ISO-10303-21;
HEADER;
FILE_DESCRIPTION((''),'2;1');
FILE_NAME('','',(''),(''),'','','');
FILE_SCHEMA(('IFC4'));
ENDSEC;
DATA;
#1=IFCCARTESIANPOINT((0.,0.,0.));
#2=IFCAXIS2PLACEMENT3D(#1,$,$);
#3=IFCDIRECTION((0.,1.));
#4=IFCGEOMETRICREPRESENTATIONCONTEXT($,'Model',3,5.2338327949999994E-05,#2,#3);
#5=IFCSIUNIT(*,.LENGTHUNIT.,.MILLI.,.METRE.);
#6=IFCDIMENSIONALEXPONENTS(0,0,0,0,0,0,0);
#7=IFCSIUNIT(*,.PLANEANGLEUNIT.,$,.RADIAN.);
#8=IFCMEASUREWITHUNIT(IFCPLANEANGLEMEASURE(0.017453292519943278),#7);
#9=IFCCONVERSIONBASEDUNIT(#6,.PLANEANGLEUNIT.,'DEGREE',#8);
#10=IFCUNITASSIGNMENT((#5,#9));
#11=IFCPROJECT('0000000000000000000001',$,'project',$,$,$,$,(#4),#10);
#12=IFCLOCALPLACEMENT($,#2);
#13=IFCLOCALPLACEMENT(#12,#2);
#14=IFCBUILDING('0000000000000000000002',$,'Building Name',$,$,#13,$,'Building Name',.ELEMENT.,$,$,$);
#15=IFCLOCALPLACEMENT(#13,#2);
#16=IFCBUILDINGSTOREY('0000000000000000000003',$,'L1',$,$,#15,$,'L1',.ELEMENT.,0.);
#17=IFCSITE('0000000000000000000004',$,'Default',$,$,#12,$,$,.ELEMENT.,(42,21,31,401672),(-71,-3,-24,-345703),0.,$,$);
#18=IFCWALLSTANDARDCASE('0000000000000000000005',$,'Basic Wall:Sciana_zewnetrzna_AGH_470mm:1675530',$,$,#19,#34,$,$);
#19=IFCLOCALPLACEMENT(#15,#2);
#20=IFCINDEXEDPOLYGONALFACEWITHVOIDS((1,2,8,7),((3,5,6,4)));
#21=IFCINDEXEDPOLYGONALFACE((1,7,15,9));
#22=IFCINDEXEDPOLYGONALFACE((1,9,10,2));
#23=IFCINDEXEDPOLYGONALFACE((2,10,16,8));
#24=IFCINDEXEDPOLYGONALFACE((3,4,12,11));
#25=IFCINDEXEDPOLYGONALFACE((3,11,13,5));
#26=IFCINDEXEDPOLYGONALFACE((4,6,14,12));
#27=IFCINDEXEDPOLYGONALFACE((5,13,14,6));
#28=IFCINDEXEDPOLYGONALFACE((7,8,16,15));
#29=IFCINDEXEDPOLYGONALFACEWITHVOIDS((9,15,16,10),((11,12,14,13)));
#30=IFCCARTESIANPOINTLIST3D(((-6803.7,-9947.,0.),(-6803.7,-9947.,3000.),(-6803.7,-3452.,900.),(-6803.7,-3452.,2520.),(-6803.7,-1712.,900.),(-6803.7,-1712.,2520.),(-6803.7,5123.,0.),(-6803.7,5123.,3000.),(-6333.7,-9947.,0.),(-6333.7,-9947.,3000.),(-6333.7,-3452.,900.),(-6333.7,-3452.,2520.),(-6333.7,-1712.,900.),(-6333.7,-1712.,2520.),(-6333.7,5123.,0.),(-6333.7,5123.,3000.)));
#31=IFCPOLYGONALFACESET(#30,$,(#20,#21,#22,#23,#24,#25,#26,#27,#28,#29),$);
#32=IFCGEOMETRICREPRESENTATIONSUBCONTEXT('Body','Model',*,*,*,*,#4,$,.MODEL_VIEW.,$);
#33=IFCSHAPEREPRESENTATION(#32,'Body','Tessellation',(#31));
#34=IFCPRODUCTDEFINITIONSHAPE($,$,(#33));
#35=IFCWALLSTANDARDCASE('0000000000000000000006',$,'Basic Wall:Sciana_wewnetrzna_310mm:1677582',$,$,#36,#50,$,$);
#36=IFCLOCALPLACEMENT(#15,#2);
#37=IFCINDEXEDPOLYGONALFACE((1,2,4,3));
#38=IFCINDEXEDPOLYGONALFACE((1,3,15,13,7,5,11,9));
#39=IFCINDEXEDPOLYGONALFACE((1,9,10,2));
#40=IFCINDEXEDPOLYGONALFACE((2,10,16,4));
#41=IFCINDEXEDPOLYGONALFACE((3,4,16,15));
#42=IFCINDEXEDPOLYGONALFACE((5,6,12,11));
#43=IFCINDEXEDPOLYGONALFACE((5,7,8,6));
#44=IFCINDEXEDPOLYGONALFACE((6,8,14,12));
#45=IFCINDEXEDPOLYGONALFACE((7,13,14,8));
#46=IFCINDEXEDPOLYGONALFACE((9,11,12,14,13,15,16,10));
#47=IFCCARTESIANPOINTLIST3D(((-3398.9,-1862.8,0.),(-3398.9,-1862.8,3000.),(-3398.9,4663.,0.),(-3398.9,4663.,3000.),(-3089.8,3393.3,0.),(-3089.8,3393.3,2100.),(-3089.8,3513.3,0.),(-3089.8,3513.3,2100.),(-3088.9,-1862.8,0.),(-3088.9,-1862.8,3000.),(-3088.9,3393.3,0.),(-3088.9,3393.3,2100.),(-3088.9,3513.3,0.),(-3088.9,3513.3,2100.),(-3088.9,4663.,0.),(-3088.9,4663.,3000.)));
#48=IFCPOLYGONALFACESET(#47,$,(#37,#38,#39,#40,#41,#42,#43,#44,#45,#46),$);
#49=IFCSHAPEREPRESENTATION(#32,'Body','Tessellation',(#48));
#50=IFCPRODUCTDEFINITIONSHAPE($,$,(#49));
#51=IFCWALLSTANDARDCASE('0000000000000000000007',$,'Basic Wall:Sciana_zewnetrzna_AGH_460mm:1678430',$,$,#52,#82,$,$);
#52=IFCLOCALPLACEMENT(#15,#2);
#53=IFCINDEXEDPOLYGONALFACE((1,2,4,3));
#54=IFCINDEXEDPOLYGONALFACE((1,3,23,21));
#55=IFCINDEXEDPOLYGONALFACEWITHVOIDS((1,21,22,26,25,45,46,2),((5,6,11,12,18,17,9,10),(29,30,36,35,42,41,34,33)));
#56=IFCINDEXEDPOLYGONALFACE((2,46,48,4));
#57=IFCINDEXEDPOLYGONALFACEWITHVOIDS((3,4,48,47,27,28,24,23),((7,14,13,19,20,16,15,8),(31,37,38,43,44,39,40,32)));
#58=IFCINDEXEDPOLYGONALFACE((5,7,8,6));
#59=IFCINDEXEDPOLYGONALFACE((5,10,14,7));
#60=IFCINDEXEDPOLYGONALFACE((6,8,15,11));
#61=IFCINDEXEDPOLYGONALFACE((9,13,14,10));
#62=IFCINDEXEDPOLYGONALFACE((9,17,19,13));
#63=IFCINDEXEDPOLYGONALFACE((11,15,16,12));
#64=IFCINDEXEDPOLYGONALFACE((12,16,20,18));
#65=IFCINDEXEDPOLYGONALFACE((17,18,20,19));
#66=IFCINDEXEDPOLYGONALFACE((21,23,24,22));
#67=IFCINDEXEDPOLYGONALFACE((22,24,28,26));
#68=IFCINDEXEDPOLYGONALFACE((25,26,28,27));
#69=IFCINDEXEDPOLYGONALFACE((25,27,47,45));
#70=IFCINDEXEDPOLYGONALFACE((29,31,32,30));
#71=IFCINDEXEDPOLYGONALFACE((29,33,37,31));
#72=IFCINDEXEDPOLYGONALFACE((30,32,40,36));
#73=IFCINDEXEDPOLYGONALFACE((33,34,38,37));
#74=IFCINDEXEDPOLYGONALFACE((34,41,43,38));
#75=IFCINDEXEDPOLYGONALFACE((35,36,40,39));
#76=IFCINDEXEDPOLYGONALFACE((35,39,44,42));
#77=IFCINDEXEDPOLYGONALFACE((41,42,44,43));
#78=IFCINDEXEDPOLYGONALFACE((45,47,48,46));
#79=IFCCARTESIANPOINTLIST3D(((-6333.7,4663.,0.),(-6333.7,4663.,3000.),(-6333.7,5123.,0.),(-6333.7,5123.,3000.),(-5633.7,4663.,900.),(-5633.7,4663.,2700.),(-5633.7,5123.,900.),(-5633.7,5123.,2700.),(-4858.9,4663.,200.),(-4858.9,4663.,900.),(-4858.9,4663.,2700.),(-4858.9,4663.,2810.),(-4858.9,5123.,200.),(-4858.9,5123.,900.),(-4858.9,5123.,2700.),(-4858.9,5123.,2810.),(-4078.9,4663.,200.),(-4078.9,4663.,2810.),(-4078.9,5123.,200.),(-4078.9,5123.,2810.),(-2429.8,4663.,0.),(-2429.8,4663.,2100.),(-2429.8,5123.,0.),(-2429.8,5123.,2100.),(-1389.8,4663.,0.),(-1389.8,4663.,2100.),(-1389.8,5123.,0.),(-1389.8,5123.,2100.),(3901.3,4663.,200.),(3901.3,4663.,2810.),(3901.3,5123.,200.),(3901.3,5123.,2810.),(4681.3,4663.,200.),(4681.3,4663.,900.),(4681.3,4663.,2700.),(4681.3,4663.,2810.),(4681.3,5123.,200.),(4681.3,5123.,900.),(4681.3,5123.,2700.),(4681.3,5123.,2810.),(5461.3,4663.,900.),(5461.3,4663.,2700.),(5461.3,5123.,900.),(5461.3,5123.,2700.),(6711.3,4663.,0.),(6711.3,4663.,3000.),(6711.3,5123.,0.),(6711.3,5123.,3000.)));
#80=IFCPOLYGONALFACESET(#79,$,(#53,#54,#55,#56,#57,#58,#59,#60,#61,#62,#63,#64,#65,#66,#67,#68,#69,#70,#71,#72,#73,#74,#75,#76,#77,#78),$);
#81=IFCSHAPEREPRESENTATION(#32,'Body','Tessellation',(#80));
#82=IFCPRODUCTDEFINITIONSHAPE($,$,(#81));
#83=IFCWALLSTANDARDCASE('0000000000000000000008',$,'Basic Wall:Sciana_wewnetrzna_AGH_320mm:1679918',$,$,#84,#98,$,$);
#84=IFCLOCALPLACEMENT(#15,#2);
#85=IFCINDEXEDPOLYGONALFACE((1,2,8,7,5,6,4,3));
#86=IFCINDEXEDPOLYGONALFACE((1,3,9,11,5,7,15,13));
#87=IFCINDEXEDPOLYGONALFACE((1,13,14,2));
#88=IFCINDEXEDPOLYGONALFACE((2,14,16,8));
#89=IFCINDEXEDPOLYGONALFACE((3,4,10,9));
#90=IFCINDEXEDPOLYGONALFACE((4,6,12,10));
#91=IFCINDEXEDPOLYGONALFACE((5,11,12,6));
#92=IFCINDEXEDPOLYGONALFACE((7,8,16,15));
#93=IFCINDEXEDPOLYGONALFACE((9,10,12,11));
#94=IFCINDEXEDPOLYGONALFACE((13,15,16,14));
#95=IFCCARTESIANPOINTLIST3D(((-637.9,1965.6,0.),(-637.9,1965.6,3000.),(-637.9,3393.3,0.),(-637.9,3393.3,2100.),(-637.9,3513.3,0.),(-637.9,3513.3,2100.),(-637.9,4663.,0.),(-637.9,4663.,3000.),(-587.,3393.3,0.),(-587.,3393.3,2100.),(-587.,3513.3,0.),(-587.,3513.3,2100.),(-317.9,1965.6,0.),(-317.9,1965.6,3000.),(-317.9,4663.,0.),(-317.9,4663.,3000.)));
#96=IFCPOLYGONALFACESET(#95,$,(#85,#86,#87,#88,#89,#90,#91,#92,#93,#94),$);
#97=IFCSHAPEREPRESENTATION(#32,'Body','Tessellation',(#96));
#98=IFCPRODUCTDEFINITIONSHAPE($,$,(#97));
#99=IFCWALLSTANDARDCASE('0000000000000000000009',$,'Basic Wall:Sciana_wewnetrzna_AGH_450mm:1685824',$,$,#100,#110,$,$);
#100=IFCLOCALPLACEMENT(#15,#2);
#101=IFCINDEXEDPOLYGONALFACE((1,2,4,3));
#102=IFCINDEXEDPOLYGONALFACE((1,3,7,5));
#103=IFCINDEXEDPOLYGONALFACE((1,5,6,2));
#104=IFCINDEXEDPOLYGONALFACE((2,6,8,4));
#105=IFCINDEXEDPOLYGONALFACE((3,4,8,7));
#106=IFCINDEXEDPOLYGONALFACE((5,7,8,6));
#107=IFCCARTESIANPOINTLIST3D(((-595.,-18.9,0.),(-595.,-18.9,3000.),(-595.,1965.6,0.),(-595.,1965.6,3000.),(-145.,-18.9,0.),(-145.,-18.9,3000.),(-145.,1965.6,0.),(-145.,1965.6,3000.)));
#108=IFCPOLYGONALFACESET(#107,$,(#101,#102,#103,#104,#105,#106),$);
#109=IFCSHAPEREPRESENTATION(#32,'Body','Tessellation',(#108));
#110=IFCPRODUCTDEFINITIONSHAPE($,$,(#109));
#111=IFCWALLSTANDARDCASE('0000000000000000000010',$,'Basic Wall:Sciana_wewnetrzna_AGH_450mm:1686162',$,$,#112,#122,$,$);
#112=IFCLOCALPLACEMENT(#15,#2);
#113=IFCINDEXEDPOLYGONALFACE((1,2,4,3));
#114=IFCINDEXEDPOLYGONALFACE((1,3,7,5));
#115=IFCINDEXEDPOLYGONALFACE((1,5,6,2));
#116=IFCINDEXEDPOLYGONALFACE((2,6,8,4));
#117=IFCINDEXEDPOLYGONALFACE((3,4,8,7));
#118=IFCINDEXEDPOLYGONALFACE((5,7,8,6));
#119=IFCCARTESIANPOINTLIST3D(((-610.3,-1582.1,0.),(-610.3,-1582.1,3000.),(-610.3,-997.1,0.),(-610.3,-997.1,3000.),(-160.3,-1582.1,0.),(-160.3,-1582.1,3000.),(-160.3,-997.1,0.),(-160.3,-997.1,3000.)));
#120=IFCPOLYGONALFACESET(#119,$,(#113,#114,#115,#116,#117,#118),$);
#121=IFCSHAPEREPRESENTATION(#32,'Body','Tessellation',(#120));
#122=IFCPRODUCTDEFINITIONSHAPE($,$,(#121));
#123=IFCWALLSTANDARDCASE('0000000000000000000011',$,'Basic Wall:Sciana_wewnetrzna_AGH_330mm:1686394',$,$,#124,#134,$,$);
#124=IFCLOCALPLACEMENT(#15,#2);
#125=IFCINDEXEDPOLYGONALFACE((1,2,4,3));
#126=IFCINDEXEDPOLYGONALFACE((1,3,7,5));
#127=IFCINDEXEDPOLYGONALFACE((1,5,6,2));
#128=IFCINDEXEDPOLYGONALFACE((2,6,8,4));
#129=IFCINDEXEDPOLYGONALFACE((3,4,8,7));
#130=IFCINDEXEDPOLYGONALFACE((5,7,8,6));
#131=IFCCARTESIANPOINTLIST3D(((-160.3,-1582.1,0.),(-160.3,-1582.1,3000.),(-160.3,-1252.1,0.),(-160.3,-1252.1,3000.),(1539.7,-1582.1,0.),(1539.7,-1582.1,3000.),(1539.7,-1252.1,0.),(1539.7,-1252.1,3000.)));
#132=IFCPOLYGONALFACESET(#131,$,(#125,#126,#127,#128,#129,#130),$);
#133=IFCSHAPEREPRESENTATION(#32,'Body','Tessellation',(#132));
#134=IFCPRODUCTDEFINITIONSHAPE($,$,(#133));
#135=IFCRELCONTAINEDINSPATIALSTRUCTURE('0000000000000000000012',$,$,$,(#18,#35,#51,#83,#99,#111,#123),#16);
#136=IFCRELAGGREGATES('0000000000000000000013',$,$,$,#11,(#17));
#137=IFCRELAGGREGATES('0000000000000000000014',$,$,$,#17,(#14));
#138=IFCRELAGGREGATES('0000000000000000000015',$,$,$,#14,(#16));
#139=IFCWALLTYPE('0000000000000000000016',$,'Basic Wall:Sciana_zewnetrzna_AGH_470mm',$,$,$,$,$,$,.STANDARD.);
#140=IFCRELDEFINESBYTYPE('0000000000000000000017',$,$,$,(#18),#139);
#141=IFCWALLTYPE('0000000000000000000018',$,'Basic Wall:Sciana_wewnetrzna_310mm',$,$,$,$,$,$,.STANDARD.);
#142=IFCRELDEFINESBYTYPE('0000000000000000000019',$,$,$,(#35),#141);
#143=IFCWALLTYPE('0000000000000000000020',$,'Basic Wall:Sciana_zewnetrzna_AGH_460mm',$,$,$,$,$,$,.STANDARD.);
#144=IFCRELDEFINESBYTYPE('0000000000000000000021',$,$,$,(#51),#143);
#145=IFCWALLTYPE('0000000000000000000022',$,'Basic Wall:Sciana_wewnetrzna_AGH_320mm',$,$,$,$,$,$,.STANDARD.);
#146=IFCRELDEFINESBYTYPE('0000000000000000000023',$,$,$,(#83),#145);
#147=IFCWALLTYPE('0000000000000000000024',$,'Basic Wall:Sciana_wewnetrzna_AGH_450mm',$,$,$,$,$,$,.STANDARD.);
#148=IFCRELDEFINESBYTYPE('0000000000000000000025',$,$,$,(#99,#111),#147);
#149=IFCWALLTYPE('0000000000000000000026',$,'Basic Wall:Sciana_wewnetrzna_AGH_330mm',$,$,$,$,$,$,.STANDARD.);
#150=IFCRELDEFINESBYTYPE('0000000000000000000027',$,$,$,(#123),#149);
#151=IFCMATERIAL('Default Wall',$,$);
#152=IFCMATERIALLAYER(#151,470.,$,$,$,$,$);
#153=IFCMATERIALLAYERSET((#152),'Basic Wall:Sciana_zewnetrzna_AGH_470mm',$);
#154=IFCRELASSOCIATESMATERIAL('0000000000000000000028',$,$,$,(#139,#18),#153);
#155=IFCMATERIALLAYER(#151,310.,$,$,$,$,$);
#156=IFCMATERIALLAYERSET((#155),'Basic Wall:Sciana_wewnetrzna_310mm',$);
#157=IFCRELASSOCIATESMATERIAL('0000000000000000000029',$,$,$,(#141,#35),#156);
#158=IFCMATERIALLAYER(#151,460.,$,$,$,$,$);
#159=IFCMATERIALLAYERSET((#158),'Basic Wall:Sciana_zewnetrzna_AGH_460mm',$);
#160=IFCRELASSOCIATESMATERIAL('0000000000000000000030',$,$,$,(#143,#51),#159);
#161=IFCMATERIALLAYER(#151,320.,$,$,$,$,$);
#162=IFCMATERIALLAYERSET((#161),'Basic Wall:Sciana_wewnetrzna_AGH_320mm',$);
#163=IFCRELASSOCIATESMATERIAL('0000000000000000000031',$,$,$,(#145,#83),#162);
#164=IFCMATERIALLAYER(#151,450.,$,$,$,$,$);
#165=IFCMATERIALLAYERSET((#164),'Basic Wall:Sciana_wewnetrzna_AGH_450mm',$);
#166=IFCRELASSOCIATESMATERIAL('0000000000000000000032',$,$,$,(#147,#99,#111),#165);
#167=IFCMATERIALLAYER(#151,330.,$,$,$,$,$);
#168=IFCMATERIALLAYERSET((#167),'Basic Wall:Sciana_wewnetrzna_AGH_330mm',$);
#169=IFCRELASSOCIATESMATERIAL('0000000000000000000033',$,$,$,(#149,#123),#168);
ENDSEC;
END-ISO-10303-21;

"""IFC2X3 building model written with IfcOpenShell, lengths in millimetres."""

from ifc_helpers import new_model, entity, si_unit, converted_unit, direction, frame, frame_2d, origin, place, context, subcontext, project, spatial, rectangle, extrude, material, layer, layer_set, layer_usage, type_object, element, save


model = new_model("IFC2X3")

# Units and contexts
model_context = context("Model", 3, precision=5.2338327949999994e-05, world=origin(), true_north=direction((0.0, 1.0)))
body_context = subcontext(model_context, "Body", "Model", "MODEL_VIEW")
ifc_project = project(units=[si_unit("LENGTHUNIT", "METRE", prefix="MILLI"), converted_unit("PLANEANGLEUNIT", "DEGREE", entity("IfcPlaneAngleMeasure", 0.017453292519943278), si_unit("PLANEANGLEUNIT", "RADIAN"), dimensions=[0, 0, 0, 0, 0, 0, 0])], contexts=[model_context])

# Site, building, storey
site_placement = place(None, origin())
site = spatial("IfcSite", under=ifc_project, at=site_placement, Name="Default", CompositionType="ELEMENT", RefLatitude=(42, 21, 31, 401672), RefLongitude=(-71, -3, -24, -345703), RefElevation=0.0)
building_placement = place(site_placement, origin())
building = spatial("IfcBuilding", under=site, at=building_placement, Name="Building Name", LongName="Building Name", CompositionType="ELEMENT")
storey_placement = place(building_placement, origin())
storey = spatial("IfcBuildingStorey", under=building, at=storey_placement, Name="L1", LongName="L1", CompositionType="ELEMENT", Elevation=0.0)

# Walls, openings
ifc_material_1 = material(Name="Default Wall")
ifc_layer_1 = layer(ifc_material_1, 470.0)
ifc_layer_set_1 = layer_set([ifc_layer_1], Name="Basic Wall:Sciana_zewnetrzna_AGH_470mm")
ifc_layer_usage_1 = layer_usage(ifc_layer_set_1, "AXIS2", "NEGATIVE", 235.0)
wall_type_1 = type_object("IfcWallType", Name="Basic Wall:Sciana_zewnetrzna_AGH_470mm", PredefinedType="STANDARD", material=ifc_layer_set_1)
wall_1_placement = place(storey_placement, frame((-6568.7, 5123.0, 0.0), z_axis=(0.0, 0.0, 1.0), x_axis=(0.0, -1.0, 0.0)))
wall_1 = element("IfcWallStandardCase", 1, at=wall_1_placement, inside=storey, type_object=wall_type_1, material=ifc_layer_usage_1, Name="Basic Wall:Sciana_zewnetrzna_AGH_470mm:1675530", context=body_context, shape_type="SweptSolid", body=[
    extrude(rectangle(XDim=15070.0, YDim=470.0, at=frame_2d((7535.0, 0.0), x_axis=(-1.0, 0.0))), origin(), (0.0, 0.0, 1.0), 3000.0),
])
opening_1_placement = place(wall_1_placement, frame((8575.0, 235.0, 900.0)))
element("IfcOpeningElement", 2, at=opening_1_placement, cuts=wall_1, ObjectType="Opening", context=body_context, shape_type="SweptSolid", body=[
    extrude(rectangle(XDim=1620.0, YDim=1740.0, at=frame_2d((810.0, 870.0), x_axis=(-1.0, 0.0))), frame((0.0, 0.0, 0.0), z_axis=(0.0, -1.0, 0.0), x_axis=(0.0, 0.0, 1.0)), (0.0, 0.0, 1.0), 470.0),
])
ifc_layer_2 = layer(ifc_material_1, 310.0)
ifc_layer_set_2 = layer_set([ifc_layer_2], Name="Basic Wall:Sciana_wewnetrzna_310mm")
ifc_layer_usage_2 = layer_usage(ifc_layer_set_2, "AXIS2", "NEGATIVE", 155.0)
wall_type_2 = type_object("IfcWallType", Name="Basic Wall:Sciana_wewnetrzna_310mm", PredefinedType="STANDARD", material=ifc_layer_set_2)
wall_2_placement = place(storey_placement, frame((-3243.9, -1862.8, 0.0), z_axis=(0.0, 0.0, 1.0), x_axis=(0.0, 1.0, 0.0)))
wall_2 = element("IfcWallStandardCase", 3, at=wall_2_placement, inside=storey, type_object=wall_type_2, material=ifc_layer_usage_2, Name="Basic Wall:Sciana_wewnetrzna_310mm:1677582", context=body_context, shape_type="SweptSolid", body=[
    extrude(rectangle(XDim=6525.8, YDim=310.0, at=frame_2d((3262.9, 0.0), x_axis=(-1.0, 0.0))), origin(), (0.0, 0.0, 1.0), 3000.0),
])
opening_2_placement = place(wall_2_placement, origin())
element("IfcOpeningElement", 4, at=opening_2_placement, cuts=wall_2, ObjectType="Opening", context=body_context, shape_type="SweptSolid", body=[
    extrude(rectangle(XDim=2100.0, YDim=120.0, at=frame_2d((0.0, 0.0), x_axis=(0.0, 1.0))), frame((5316.0, -1154.1, 1050.0), z_axis=(0.0, 1.0, 0.0), x_axis=(-1.0, 0.0, 0.0)), (0.0, 0.0, 1.0), 1000.0),
])

# Wall, openings
ifc_layer_3 = layer(ifc_material_1, 460.0)
ifc_layer_set_3 = layer_set([ifc_layer_3], Name="Basic Wall:Sciana_zewnetrzna_AGH_460mm")
ifc_layer_usage_3 = layer_usage(ifc_layer_set_3, "AXIS2", "NEGATIVE", 230.0)
wall_type_3 = type_object("IfcWallType", Name="Basic Wall:Sciana_zewnetrzna_AGH_460mm", PredefinedType="STANDARD", material=ifc_layer_set_3)
wall_3_placement = place(storey_placement, frame((-6333.7, 4893.0, 0.0)))
wall_3 = element("IfcWallStandardCase", 5, at=wall_3_placement, inside=storey, type_object=wall_type_3, material=ifc_layer_usage_3, Name="Basic Wall:Sciana_zewnetrzna_AGH_460mm:1678430", context=body_context, shape_type="SweptSolid", body=[
    extrude(rectangle(XDim=13045.0, YDim=460.0, at=frame_2d((6522.5, 0.0), x_axis=(-1.0, 0.0))), origin(), (0.0, 0.0, 1.0), 3000.0),
])
opening_3_placement = place(wall_3_placement, frame((4943.9, 230.0, 0.0)))
element("IfcOpeningElement", 6, at=opening_3_placement, cuts=wall_3, ObjectType="Opening", context=body_context, shape_type="SweptSolid", body=[
    extrude(rectangle(XDim=2100.0, YDim=1040.0, at=frame_2d((1050.0, 520.0), x_axis=(1.0, 0.0))), frame((0.0, 0.0, 0.0), z_axis=(0.0, -1.0, 0.0), x_axis=(0.0, 0.0, 1.0)), (0.0, 0.0, 1.0), 460.0),
])
opening_4_placement = place(wall_3_placement, frame((700.0, -230.0, 900.0)))
element("IfcOpeningElement", 7, at=opening_4_placement, cuts=wall_3, ObjectType="Opening", context=body_context, shape_type="SweptSolid", body=[
    extrude(rectangle(XDim=1800.0, YDim=780.0, at=frame_2d((900.0, 390.0), x_axis=(-1.0, 0.0))), frame((0.0, 0.0, 0.0), z_axis=(0.0, 1.0, 0.0), x_axis=(0.0, 0.0, 1.0)), (0.0, 0.0, 1.0), 460.0),
])
opening_5_placement = place(wall_3_placement, frame((1474.8, -230.0, 200.0)))
element("IfcOpeningElement", 8, at=opening_5_placement, cuts=wall_3, ObjectType="Opening", context=body_context, shape_type="SweptSolid", body=[
    extrude(rectangle(XDim=2610.0, YDim=780.0, at=frame_2d((1305.0, 390.0), x_axis=(-1.0, 0.0))), frame((0.0, 0.0, 0.0), z_axis=(0.0, 1.0, 0.0), x_axis=(0.0, 0.0, 1.0)), (0.0, 0.0, 1.0), 460.0),
])
opening_6_placement = place(wall_3_placement, frame((10235.0, -230.0, 200.0)))
element("IfcOpeningElement", 9, at=opening_6_placement, cuts=wall_3, ObjectType="Opening", context=body_context, shape_type="SweptSolid", body=[
    extrude(rectangle(XDim=2610.0, YDim=780.0, at=frame_2d((1305.0, 390.0), x_axis=(-1.0, 0.0))), frame((0.0, 0.0, 0.0), z_axis=(0.0, 1.0, 0.0), x_axis=(0.0, 0.0, 1.0)), (0.0, 0.0, 1.0), 460.0),
])
opening_7_placement = place(wall_3_placement, frame((11015.0, -230.0, 900.0)))
element("IfcOpeningElement", 10, at=opening_7_placement, cuts=wall_3, ObjectType="Opening", context=body_context, shape_type="SweptSolid", body=[
    extrude(rectangle(XDim=1800.0, YDim=780.0, at=frame_2d((900.0, 390.0), x_axis=(-1.0, 0.0))), frame((0.0, 0.0, 0.0), z_axis=(0.0, 1.0, 0.0), x_axis=(0.0, 0.0, 1.0)), (0.0, 0.0, 1.0), 460.0),
])

# Wall, opening
ifc_layer_4 = layer(ifc_material_1, 320.0)
ifc_layer_set_4 = layer_set([ifc_layer_4], Name="Basic Wall:Sciana_wewnetrzna_AGH_320mm")
ifc_layer_usage_4 = layer_usage(ifc_layer_set_4, "AXIS2", "NEGATIVE", 160.0)
wall_type_4 = type_object("IfcWallType", Name="Basic Wall:Sciana_wewnetrzna_AGH_320mm", PredefinedType="STANDARD", material=ifc_layer_set_4)
wall_4_placement = place(storey_placement, frame((-477.9, 4663.0, 0.0), z_axis=(0.0, 0.0, 1.0), x_axis=(0.0, -1.0, 0.0)))
wall_4 = element("IfcWallStandardCase", 11, at=wall_4_placement, inside=storey, type_object=wall_type_4, material=ifc_layer_usage_4, Name="Basic Wall:Sciana_wewnetrzna_AGH_320mm:1679918", context=body_context, shape_type="SweptSolid", body=[
    extrude(rectangle(XDim=2697.4, YDim=320.0, at=frame_2d((1348.7, 0.0), x_axis=(-1.0, 0.0))), origin(), (0.0, 0.0, 1.0), 3000.0),
])
opening_8_placement = place(wall_4_placement, origin())
element("IfcOpeningElement", 12, at=opening_8_placement, cuts=wall_4, ObjectType="Opening", context=body_context, shape_type="SweptSolid", body=[
    extrude(rectangle(XDim=2100.0, YDim=120.0, at=frame_2d((0.0, 0.0), x_axis=(0.0, 1.0))), frame((1209.8, -1209.1, 1050.0), z_axis=(0.0, 1.0, 0.0), x_axis=(-1.0, 0.0, 0.0)), (0.0, 0.0, 1.0), 1100.0),
])

# Walls
ifc_layer_5 = layer(ifc_material_1, 450.0)
ifc_layer_set_5 = layer_set([ifc_layer_5], Name="Basic Wall:Sciana_wewnetrzna_AGH_450mm")
ifc_layer_usage_5 = layer_usage(ifc_layer_set_5, "AXIS2", "NEGATIVE", 225.0)
wall_type_5 = type_object("IfcWallType", Name="Basic Wall:Sciana_wewnetrzna_AGH_450mm", PredefinedType="STANDARD", material=ifc_layer_set_5)
wall_5_placement = place(storey_placement, frame((-370.0, 1965.6, 0.0), z_axis=(0.0, 0.0, 1.0), x_axis=(0.0, -1.0, 0.0)))
element("IfcWallStandardCase", 13, at=wall_5_placement, inside=storey, type_object=wall_type_5, material=ifc_layer_usage_5, Name="Basic Wall:Sciana_wewnetrzna_AGH_450mm:1685824", context=body_context, shape_type="SweptSolid", body=[
    extrude(rectangle(XDim=1984.5, YDim=450.0, at=frame_2d((992.2, 0.0), x_axis=(-1.0, 0.0))), origin(), (0.0, 0.0, 1.0), 3000.0),
])
ifc_layer_usage_6 = layer_usage(ifc_layer_set_5, "AXIS2", "NEGATIVE", 225.0)
wall_6_placement = place(storey_placement, frame((-385.3, -997.1, 0.0), z_axis=(0.0, 0.0, 1.0), x_axis=(0.0, -1.0, 0.0)))
element("IfcWallStandardCase", 14, at=wall_6_placement, inside=storey, type_object=wall_type_5, material=ifc_layer_usage_6, Name="Basic Wall:Sciana_wewnetrzna_AGH_450mm:1686162", context=body_context, shape_type="SweptSolid", body=[
    extrude(rectangle(XDim=585.0, YDim=450.0, at=frame_2d((292.5, 0.0), x_axis=(-1.0, 0.0))), origin(), (0.0, 0.0, 1.0), 3000.0),
])
ifc_layer_6 = layer(ifc_material_1, 330.0)
ifc_layer_set_6 = layer_set([ifc_layer_6], Name="Basic Wall:Sciana_wewnetrzna_AGH_330mm")
ifc_layer_usage_7 = layer_usage(ifc_layer_set_6, "AXIS2", "NEGATIVE", 165.0)
wall_type_6 = type_object("IfcWallType", Name="Basic Wall:Sciana_wewnetrzna_AGH_330mm", PredefinedType="STANDARD", material=ifc_layer_set_6)
wall_7_placement = place(storey_placement, frame((-160.3, -1417.1, 0.0)))
element("IfcWallStandardCase", 15, at=wall_7_placement, inside=storey, type_object=wall_type_6, material=ifc_layer_usage_7, Name="Basic Wall:Sciana_wewnetrzna_AGH_330mm:1686394", context=body_context, shape_type="SweptSolid", body=[
    extrude(rectangle(XDim=1700.0, YDim=330.0, at=frame_2d((850.0, 0.0), x_axis=(-1.0, 0.0))), origin(), (0.0, 0.0, 1.0), 3000.0),
])

save(model, "model.ifc")
